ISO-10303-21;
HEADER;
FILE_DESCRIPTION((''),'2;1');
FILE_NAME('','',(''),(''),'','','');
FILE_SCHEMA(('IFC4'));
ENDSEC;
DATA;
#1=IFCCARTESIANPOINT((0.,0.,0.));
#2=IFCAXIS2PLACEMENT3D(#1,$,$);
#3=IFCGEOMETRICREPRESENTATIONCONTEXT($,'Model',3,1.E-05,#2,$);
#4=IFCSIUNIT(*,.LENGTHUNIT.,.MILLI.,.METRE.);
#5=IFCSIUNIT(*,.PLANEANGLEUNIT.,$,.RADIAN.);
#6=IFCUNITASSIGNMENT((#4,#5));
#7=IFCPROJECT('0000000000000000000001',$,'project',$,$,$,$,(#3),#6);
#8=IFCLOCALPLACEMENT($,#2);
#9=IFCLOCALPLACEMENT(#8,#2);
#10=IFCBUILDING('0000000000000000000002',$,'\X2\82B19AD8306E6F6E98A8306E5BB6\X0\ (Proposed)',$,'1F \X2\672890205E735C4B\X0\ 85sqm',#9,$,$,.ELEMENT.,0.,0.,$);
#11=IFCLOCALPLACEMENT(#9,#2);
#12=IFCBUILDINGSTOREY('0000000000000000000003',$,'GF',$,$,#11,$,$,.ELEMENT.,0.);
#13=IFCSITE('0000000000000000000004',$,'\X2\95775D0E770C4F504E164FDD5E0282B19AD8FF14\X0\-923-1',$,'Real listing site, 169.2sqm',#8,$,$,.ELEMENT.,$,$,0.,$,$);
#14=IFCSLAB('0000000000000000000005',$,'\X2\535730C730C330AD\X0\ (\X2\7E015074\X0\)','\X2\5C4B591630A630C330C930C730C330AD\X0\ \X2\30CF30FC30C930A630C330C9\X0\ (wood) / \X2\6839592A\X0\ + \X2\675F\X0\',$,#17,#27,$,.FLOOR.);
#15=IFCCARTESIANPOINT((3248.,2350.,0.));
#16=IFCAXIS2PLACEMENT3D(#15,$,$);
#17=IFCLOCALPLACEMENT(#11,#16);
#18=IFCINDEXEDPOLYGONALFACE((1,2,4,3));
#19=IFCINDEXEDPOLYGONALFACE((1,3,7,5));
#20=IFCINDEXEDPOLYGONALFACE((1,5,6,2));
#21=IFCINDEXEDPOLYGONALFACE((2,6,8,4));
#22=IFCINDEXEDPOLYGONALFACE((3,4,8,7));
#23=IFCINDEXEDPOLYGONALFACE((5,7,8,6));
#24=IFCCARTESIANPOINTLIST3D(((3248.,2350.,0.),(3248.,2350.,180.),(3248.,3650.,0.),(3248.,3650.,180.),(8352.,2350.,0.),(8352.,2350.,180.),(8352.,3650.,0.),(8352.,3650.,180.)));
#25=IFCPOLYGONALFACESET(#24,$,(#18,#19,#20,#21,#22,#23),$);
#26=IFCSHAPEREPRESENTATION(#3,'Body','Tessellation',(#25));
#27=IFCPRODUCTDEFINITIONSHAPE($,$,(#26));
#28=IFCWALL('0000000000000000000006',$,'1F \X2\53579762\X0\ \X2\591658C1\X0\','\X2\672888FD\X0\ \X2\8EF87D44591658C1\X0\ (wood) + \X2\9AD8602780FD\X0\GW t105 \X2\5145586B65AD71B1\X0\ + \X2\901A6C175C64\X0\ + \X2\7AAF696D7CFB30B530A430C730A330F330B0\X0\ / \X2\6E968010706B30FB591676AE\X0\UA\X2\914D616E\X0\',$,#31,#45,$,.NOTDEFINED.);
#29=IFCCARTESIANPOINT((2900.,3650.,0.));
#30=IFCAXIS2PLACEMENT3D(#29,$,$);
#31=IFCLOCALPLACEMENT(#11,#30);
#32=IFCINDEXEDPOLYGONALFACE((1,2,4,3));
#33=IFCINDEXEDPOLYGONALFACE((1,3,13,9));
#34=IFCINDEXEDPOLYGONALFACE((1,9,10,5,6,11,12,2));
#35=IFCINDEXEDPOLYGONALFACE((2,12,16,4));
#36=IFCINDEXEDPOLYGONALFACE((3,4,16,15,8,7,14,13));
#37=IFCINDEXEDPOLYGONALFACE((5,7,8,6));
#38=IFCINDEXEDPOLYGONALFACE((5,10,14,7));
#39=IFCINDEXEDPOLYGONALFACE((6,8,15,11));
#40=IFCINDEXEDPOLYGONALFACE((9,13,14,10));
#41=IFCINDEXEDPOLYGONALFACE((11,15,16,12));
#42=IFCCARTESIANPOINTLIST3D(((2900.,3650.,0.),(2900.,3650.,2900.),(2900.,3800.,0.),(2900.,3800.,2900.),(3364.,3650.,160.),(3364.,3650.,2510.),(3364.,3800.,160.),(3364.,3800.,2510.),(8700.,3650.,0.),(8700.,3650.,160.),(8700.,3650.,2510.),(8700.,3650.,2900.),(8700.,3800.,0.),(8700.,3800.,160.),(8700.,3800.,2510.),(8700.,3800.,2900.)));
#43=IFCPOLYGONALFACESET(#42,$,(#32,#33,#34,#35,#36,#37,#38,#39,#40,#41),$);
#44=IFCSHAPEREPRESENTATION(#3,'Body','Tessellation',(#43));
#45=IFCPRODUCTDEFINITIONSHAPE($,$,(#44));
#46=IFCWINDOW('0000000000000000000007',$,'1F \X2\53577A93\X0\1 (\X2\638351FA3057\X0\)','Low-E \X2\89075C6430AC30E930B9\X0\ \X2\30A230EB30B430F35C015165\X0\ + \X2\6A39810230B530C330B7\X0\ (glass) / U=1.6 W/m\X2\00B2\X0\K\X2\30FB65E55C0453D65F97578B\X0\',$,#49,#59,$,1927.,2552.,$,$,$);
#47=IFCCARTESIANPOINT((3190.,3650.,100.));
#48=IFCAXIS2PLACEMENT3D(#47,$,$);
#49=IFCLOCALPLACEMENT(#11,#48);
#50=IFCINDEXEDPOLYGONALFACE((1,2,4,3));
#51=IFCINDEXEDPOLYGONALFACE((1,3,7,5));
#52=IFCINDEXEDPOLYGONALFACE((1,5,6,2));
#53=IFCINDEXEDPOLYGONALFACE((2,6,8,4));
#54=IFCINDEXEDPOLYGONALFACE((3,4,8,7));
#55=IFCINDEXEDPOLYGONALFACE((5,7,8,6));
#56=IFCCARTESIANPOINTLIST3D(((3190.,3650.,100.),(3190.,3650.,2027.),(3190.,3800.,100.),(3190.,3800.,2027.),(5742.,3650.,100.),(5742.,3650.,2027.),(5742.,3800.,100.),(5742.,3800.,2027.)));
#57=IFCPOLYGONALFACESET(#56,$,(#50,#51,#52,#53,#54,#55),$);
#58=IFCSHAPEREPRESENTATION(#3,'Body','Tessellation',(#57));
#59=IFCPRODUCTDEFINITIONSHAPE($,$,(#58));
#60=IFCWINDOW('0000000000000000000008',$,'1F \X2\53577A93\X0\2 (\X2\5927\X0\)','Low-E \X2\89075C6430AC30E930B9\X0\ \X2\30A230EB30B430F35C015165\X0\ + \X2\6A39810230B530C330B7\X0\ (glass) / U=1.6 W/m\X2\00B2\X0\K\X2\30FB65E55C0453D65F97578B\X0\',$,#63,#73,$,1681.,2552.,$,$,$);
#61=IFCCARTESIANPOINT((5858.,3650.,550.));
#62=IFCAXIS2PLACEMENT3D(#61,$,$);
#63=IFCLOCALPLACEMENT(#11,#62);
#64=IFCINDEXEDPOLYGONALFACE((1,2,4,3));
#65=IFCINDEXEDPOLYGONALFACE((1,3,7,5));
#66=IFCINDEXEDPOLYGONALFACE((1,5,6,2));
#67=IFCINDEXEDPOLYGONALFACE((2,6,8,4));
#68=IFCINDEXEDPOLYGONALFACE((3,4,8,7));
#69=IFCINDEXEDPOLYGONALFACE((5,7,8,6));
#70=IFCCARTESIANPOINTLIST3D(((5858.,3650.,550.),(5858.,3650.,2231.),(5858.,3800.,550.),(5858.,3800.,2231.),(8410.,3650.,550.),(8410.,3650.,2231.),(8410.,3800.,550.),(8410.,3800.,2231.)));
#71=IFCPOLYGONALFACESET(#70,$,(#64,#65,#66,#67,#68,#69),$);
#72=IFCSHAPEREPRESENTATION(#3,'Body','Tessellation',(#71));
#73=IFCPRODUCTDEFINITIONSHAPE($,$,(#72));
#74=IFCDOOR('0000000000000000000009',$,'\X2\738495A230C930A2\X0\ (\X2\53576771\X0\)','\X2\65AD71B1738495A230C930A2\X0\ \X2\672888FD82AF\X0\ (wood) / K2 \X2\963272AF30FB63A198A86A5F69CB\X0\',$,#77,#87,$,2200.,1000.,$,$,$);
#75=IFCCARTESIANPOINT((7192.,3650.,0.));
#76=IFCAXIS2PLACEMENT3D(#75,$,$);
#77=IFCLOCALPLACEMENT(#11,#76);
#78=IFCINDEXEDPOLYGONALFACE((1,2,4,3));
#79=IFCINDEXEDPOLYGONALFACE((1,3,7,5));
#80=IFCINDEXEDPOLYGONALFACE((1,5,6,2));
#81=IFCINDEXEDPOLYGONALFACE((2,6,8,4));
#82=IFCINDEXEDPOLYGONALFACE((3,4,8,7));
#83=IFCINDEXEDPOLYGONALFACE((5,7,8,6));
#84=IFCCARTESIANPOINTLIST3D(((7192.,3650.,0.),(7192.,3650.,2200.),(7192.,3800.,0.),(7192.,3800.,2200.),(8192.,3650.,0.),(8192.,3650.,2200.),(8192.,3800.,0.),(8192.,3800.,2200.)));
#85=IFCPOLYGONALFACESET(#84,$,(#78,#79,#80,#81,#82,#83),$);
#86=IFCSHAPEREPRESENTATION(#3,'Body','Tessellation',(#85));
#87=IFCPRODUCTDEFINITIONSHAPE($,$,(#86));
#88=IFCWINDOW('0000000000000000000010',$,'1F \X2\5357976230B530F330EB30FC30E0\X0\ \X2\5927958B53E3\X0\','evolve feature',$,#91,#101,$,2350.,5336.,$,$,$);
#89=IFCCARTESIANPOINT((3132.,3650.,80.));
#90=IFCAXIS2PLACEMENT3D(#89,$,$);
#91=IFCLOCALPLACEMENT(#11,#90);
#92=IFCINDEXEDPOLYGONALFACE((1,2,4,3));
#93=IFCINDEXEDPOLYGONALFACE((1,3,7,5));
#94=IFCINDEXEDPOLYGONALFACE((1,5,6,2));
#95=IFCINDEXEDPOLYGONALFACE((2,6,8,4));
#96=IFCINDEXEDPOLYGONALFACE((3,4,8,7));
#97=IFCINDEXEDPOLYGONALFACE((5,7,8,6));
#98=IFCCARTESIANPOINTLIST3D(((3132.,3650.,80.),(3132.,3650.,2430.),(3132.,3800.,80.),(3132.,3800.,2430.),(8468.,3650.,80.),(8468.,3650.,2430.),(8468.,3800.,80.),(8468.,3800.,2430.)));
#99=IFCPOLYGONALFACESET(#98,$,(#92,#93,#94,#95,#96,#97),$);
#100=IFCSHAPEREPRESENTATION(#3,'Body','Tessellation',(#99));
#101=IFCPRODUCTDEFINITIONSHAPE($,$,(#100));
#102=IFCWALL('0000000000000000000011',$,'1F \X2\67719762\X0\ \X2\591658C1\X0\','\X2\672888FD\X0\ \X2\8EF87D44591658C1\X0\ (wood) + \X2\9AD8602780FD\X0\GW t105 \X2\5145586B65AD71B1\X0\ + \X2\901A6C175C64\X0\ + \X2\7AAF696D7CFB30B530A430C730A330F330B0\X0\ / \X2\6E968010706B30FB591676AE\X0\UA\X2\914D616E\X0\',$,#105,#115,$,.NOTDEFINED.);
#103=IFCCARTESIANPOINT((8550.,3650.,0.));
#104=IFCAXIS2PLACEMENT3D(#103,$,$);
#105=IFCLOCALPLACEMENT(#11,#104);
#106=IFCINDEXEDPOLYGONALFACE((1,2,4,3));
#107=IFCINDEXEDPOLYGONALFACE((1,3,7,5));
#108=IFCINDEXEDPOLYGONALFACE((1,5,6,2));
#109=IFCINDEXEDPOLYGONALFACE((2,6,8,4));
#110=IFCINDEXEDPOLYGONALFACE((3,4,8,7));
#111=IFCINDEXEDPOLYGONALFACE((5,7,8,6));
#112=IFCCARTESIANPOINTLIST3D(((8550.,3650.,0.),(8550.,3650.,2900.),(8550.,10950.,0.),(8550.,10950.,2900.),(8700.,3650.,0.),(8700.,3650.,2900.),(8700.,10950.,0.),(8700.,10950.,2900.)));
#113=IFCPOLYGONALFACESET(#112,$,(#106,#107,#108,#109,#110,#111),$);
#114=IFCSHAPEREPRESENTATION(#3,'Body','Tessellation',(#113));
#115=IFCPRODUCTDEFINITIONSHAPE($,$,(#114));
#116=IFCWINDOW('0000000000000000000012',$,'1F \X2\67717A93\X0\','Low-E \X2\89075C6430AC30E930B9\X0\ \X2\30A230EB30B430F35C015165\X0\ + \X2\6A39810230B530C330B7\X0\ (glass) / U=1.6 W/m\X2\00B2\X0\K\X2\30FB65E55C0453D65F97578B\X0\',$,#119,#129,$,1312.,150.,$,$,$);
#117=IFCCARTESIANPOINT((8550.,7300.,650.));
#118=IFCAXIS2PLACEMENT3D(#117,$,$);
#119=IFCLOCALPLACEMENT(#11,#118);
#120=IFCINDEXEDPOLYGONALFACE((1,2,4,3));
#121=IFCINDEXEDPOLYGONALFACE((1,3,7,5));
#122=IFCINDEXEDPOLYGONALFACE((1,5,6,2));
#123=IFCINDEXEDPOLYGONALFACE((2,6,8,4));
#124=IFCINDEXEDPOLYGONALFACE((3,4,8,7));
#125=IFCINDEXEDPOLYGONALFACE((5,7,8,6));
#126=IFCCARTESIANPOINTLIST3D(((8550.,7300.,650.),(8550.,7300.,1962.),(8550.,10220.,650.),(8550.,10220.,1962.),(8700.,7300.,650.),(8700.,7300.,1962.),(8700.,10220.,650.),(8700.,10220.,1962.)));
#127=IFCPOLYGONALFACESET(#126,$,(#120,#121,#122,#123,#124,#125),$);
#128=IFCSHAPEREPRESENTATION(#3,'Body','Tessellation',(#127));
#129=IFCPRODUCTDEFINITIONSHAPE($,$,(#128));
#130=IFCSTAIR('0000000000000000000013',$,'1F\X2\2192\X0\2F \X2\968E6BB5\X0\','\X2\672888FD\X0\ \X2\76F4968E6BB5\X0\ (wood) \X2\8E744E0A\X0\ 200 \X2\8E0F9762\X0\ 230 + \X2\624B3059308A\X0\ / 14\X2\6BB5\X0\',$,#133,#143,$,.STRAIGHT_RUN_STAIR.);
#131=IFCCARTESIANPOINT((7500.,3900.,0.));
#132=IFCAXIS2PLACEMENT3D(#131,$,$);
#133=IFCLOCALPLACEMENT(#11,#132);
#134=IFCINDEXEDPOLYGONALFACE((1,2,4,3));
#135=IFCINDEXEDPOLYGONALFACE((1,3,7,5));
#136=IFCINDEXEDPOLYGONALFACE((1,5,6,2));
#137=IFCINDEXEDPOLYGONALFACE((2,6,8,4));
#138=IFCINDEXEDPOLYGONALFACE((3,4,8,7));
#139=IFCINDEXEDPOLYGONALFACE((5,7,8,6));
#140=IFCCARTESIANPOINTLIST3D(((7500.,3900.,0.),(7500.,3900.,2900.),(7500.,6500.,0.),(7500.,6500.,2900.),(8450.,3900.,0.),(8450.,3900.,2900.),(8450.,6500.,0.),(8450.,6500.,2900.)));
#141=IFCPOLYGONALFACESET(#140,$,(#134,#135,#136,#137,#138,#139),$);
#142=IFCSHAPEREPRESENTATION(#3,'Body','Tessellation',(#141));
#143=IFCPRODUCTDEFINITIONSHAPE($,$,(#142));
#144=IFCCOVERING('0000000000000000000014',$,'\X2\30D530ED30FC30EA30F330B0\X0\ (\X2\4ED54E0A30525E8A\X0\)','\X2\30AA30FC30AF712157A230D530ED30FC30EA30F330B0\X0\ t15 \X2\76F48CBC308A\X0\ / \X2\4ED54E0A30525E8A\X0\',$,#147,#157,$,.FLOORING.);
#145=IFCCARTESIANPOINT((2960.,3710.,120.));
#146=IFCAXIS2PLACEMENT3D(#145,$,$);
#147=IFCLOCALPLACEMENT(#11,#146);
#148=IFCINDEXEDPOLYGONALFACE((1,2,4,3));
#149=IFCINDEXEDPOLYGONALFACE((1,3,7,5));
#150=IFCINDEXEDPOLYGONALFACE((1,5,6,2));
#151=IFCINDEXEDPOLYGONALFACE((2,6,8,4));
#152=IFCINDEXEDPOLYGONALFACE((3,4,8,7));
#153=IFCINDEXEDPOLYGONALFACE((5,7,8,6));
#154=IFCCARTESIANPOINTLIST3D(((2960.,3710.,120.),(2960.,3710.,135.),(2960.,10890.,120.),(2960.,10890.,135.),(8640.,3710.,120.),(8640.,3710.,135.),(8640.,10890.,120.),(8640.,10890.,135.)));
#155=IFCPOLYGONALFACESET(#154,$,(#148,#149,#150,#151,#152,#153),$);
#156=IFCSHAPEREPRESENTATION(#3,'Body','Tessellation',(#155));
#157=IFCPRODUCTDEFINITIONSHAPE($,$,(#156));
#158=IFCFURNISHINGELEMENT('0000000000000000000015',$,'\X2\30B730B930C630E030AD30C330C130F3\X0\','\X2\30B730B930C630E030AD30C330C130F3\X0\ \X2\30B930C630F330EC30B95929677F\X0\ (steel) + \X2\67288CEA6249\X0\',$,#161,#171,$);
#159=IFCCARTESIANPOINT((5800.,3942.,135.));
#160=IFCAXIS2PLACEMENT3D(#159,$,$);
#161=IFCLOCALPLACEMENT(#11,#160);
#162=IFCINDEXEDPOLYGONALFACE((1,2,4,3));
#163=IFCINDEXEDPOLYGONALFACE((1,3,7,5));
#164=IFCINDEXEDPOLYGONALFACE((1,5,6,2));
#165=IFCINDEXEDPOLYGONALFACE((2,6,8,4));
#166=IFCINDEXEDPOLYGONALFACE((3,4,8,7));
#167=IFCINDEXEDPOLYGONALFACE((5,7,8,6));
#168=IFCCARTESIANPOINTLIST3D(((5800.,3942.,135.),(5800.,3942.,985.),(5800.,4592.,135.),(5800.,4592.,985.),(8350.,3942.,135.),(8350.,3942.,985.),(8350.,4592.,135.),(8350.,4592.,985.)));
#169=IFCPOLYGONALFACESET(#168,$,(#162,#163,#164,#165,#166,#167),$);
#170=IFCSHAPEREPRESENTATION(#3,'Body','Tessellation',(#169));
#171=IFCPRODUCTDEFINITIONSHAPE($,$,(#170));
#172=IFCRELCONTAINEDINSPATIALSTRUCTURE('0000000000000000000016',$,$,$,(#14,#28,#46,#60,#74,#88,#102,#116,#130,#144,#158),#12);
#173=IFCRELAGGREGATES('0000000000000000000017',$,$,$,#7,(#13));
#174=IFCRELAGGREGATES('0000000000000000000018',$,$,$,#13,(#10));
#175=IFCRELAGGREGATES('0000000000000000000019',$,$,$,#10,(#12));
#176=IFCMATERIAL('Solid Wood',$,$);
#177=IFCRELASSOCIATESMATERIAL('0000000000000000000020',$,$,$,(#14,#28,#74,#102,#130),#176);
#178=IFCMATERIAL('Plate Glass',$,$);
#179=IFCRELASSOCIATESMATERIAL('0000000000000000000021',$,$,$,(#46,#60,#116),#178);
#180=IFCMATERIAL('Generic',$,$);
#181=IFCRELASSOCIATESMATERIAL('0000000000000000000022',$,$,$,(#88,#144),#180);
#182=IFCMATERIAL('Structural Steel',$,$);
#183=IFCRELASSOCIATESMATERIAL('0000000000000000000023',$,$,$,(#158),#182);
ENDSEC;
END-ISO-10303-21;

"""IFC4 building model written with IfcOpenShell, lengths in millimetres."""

from ifc_helpers import new_model, si_unit, frame, frame_2d, origin, place, context, project, spatial, rectangle, extrude, material, element, fill, save


model = new_model("IFC4")

# Units and contexts
model_context = context("Model", 3, precision=1e-05, world=origin())
ifc_project = project(units=[si_unit("LENGTHUNIT", "METRE", prefix="MILLI"), si_unit("PLANEANGLEUNIT", "RADIAN")], contexts=[model_context])

# Site, building, storey
site_placement = place(None, origin())
site = spatial("IfcSite", under=ifc_project, at=site_placement, Name="長崎県佐世保市花高４-923-1", ObjectType="Real listing site, 169.2sqm", CompositionType="ELEMENT", RefElevation=0.0)
building_placement = place(site_placement, origin())
building = spatial("IfcBuilding", under=site, at=building_placement, Name="花高の潮風の家 (Proposed)", ObjectType="1F 木造平屋 85sqm", CompositionType="ELEMENT", ElevationOfRefHeight=0.0, ElevationOfTerrain=0.0)
storey_placement = place(building_placement, origin())
storey = spatial("IfcBuildingStorey", under=building, at=storey_placement, Name="GF", CompositionType="ELEMENT", Elevation=0.0)

# Slab
ifc_material_1 = material(Name="Solid Wood")
slab_1_placement = place(storey_placement, frame((3248.0, 2350.0, 0.0)))
element("IfcSlab", 1, at=slab_1_placement, inside=storey, material=ifc_material_1, Name="南デッキ (縁側)", Description="屋外ウッドデッキ ハードウッド (wood) / 根太 + 束", PredefinedType="FLOOR", context=model_context, shape_type="SweptSolid", body=[
    extrude(rectangle(XDim=5104.0, YDim=1300.0, at=frame_2d((2552.0, 650.0))), frame((3248.0, 2350.0, 0.0)), (0.0, 0.0, 1.0), 180.0),
])
ifc_material_2 = material(Name="Generic")

# Wall, openings, windows, door
wall_1_placement = place(storey_placement, frame((2900.0, 3650.0, 0.0)))
wall_1 = element("IfcWall", 2, at=wall_1_placement, inside=storey, material=ifc_material_1, Name="1F 南面 外壁", Description="木製 軸組外壁 (wood) + 高性能GW t105 充填断熱 + 通気層 + 窯業系サイディング / 準耐火・外皮UA配慮", PredefinedType="NOTDEFINED", context=model_context, shape_type="SweptSolid", body=[
    extrude(rectangle(XDim=5800.0, YDim=150.0, at=frame_2d((2900.0, 75.0))), frame((2900.0, 3650.0, 0.0)), (0.0, 0.0, 1.0), 2900.0),
])
opening_1_placement = place(storey_placement, frame((3190.0, 3650.0, 100.0)))
opening_1 = element("IfcOpeningElement", 3, at=opening_1_placement, cuts=wall_1, PredefinedType="NOTDEFINED", context=model_context, shape_type="SweptSolid", body=[
    extrude(rectangle(XDim=2552.0, YDim=150.0, at=frame_2d((1276.0, 75.0))), frame((3190.0, 3650.0, 100.0)), (0.0, 0.0, 1.0), 1927.0),
])
opening_2_placement = place(storey_placement, frame((5858.0, 3650.0, 550.0)))
opening_2 = element("IfcOpeningElement", 4, at=opening_2_placement, cuts=wall_1, PredefinedType="NOTDEFINED", context=model_context, shape_type="SweptSolid", body=[
    extrude(rectangle(XDim=2552.0, YDim=150.0, at=frame_2d((1276.0, 75.0))), frame((5858.0, 3650.0, 550.0)), (0.0, 0.0, 1.0), 1681.0),
])
opening_3_placement = place(storey_placement, frame((7192.0, 3650.0, 0.0)))
opening_3 = element("IfcOpeningElement", 5, at=opening_3_placement, cuts=wall_1, PredefinedType="NOTDEFINED", context=model_context, shape_type="SweptSolid", body=[
    extrude(rectangle(XDim=1000.0, YDim=150.0, at=frame_2d((500.0, 75.0))), frame((7192.0, 3650.0, 0.0)), (0.0, 0.0, 1.0), 2200.0),
])
opening_4_placement = place(storey_placement, frame((3132.0, 3650.0, 80.0)))
opening_4 = element("IfcOpeningElement", 6, at=opening_4_placement, cuts=wall_1, PredefinedType="NOTDEFINED", context=model_context, shape_type="SweptSolid", body=[
    extrude(rectangle(XDim=5336.0, YDim=150.0, at=frame_2d((2668.0, 75.0))), frame((3132.0, 3650.0, 80.0)), (0.0, 0.0, 1.0), 2350.0),
])
ifc_material_3 = material(Name="Plate Glass")
window_1_placement = place(storey_placement, frame((3190.0, 3650.0, 100.0)))
window_1 = element("IfcWindow", 7, at=window_1_placement, inside=storey, material=ifc_material_3, Name="1F 南窓1 (掃出し)", Description="Low-E 複層ガラス アルゴン封入 + 樹脂サッシ (glass) / U=1.6 W/m²K・日射取得型", OverallHeight=1927.0, OverallWidth=2552.0, context=model_context, shape_type="SweptSolid", body=[
    extrude(rectangle(XDim=2552.0, YDim=150.0, at=frame_2d((1276.0, 75.0))), frame((3190.0, 3650.0, 100.0)), (0.0, 0.0, 1.0), 1927.0),
])
fill(opening_1, window_1)
window_2_placement = place(storey_placement, frame((5858.0, 3650.0, 550.0)))
window_2 = element("IfcWindow", 8, at=window_2_placement, inside=storey, material=ifc_material_3, Name="1F 南窓2 (大)", Description="Low-E 複層ガラス アルゴン封入 + 樹脂サッシ (glass) / U=1.6 W/m²K・日射取得型", OverallHeight=1681.0, OverallWidth=2552.0, context=model_context, shape_type="SweptSolid", body=[
    extrude(rectangle(XDim=2552.0, YDim=150.0, at=frame_2d((1276.0, 75.0))), frame((5858.0, 3650.0, 550.0)), (0.0, 0.0, 1.0), 1681.0),
])
fill(opening_2, window_2)
door_placement = place(storey_placement, frame((7192.0, 3650.0, 0.0)))
door = element("IfcDoor", 9, at=door_placement, inside=storey, material=ifc_material_1, Name="玄関ドア (南東)", Description="断熱玄関ドア 木製芯 (wood) / K2 防犯・採風機構", OverallHeight=2200.0, OverallWidth=1000.0, context=model_context, shape_type="SweptSolid", body=[
    extrude(rectangle(XDim=1000.0, YDim=150.0, at=frame_2d((500.0, 75.0))), frame((7192.0, 3650.0, 0.0)), (0.0, 0.0, 1.0), 2200.0),
])
fill(opening_3, door)
window_3_placement = place(storey_placement, frame((3132.0, 3650.0, 80.0)))
window_3 = element("IfcWindow", 10, at=window_3_placement, inside=storey, material=ifc_material_2, Name="1F 南面サンルーム 大開口", Description="evolve feature", OverallHeight=2350.0, OverallWidth=5336.0, context=model_context, shape_type="SweptSolid", body=[
    extrude(rectangle(XDim=5336.0, YDim=150.0, at=frame_2d((2668.0, 75.0))), frame((3132.0, 3650.0, 80.0)), (0.0, 0.0, 1.0), 2350.0),
])
fill(opening_4, window_3)

# Wall, opening, window
wall_2_placement = place(storey_placement, frame((8550.0, 3650.0, 0.0)))
wall_2 = element("IfcWall", 11, at=wall_2_placement, inside=storey, material=ifc_material_1, Name="1F 東面 外壁", Description="木製 軸組外壁 (wood) + 高性能GW t105 充填断熱 + 通気層 + 窯業系サイディング / 準耐火・外皮UA配慮", PredefinedType="NOTDEFINED", context=model_context, shape_type="SweptSolid", body=[
    extrude(rectangle(XDim=150.0, YDim=7300.0, at=frame_2d((75.0, 3650.0))), frame((8550.0, 3650.0, 0.0)), (0.0, 0.0, 1.0), 2900.0),
])
opening_5_placement = place(storey_placement, frame((8550.0, 7300.0, 650.0)))
opening_5 = element("IfcOpeningElement", 12, at=opening_5_placement, cuts=wall_2, PredefinedType="NOTDEFINED", context=model_context, shape_type="SweptSolid", body=[
    extrude(rectangle(XDim=150.0, YDim=2920.0, at=frame_2d((75.0, 1460.0))), frame((8550.0, 7300.0, 650.0)), (0.0, 0.0, 1.0), 1312.0),
])
window_4_placement = place(storey_placement, frame((8550.0, 7300.0, 650.0)))
window_4 = element("IfcWindow", 13, at=window_4_placement, inside=storey, material=ifc_material_3, Name="1F 東窓", Description="Low-E 複層ガラス アルゴン封入 + 樹脂サッシ (glass) / U=1.6 W/m²K・日射取得型", OverallHeight=1312.0, OverallWidth=150.0, context=model_context, shape_type="SweptSolid", body=[
    extrude(rectangle(XDim=150.0, YDim=2920.0, at=frame_2d((75.0, 1460.0))), frame((8550.0, 7300.0, 650.0)), (0.0, 0.0, 1.0), 1312.0),
])
fill(opening_5, window_4)

# Stair
stair_placement = place(storey_placement, frame((7500.0, 3900.0, 0.0)))
element("IfcStair", 14, at=stair_placement, inside=storey, material=ifc_material_1, Name="1F→2F 階段", Description="木製 直階段 (wood) 蹴上 200 踏面 230 + 手すり / 14段", PredefinedType="STRAIGHT_RUN_STAIR", context=model_context, shape_type="SweptSolid", body=[
    extrude(rectangle(XDim=950.0, YDim=2600.0, at=frame_2d((475.0, 1300.0))), frame((7500.0, 3900.0, 0.0)), (0.0, 0.0, 1.0), 2900.0),
])

# Covering
covering_placement = place(storey_placement, frame((2960.0, 3710.0, 120.0)))
element("IfcCovering", 15, at=covering_placement, inside=storey, material=ifc_material_2, Name="フローリング (仕上げ床)", Description="オーク無垢フローリング t15 直貼り / 仕上げ床", PredefinedType="FLOORING", context=model_context, shape_type="SweptSolid", body=[
    extrude(rectangle(XDim=5680.0, YDim=7180.0, at=frame_2d((2840.0, 3590.0))), frame((2960.0, 3710.0, 120.0)), (0.0, 0.0, 1.0), 15.0),
])

# Furnishing element
ifc_material_4 = material(Name="Structural Steel")
furnishing_placement = place(storey_placement, frame((5800.0, 3942.0, 135.0)))
element("IfcFurnishingElement", 16, at=furnishing_placement, inside=storey, material=ifc_material_4, Name="システムキッチン", Description="システムキッチン ステンレス天板 (steel) + 木質扉", context=model_context, shape_type="SweptSolid", body=[
    extrude(rectangle(XDim=2550.0, YDim=650.0, at=frame_2d((1275.0, 325.0))), frame((5800.0, 3942.0, 135.0)), (0.0, 0.0, 1.0), 850.0),
])

save(model, "model.ifc")
